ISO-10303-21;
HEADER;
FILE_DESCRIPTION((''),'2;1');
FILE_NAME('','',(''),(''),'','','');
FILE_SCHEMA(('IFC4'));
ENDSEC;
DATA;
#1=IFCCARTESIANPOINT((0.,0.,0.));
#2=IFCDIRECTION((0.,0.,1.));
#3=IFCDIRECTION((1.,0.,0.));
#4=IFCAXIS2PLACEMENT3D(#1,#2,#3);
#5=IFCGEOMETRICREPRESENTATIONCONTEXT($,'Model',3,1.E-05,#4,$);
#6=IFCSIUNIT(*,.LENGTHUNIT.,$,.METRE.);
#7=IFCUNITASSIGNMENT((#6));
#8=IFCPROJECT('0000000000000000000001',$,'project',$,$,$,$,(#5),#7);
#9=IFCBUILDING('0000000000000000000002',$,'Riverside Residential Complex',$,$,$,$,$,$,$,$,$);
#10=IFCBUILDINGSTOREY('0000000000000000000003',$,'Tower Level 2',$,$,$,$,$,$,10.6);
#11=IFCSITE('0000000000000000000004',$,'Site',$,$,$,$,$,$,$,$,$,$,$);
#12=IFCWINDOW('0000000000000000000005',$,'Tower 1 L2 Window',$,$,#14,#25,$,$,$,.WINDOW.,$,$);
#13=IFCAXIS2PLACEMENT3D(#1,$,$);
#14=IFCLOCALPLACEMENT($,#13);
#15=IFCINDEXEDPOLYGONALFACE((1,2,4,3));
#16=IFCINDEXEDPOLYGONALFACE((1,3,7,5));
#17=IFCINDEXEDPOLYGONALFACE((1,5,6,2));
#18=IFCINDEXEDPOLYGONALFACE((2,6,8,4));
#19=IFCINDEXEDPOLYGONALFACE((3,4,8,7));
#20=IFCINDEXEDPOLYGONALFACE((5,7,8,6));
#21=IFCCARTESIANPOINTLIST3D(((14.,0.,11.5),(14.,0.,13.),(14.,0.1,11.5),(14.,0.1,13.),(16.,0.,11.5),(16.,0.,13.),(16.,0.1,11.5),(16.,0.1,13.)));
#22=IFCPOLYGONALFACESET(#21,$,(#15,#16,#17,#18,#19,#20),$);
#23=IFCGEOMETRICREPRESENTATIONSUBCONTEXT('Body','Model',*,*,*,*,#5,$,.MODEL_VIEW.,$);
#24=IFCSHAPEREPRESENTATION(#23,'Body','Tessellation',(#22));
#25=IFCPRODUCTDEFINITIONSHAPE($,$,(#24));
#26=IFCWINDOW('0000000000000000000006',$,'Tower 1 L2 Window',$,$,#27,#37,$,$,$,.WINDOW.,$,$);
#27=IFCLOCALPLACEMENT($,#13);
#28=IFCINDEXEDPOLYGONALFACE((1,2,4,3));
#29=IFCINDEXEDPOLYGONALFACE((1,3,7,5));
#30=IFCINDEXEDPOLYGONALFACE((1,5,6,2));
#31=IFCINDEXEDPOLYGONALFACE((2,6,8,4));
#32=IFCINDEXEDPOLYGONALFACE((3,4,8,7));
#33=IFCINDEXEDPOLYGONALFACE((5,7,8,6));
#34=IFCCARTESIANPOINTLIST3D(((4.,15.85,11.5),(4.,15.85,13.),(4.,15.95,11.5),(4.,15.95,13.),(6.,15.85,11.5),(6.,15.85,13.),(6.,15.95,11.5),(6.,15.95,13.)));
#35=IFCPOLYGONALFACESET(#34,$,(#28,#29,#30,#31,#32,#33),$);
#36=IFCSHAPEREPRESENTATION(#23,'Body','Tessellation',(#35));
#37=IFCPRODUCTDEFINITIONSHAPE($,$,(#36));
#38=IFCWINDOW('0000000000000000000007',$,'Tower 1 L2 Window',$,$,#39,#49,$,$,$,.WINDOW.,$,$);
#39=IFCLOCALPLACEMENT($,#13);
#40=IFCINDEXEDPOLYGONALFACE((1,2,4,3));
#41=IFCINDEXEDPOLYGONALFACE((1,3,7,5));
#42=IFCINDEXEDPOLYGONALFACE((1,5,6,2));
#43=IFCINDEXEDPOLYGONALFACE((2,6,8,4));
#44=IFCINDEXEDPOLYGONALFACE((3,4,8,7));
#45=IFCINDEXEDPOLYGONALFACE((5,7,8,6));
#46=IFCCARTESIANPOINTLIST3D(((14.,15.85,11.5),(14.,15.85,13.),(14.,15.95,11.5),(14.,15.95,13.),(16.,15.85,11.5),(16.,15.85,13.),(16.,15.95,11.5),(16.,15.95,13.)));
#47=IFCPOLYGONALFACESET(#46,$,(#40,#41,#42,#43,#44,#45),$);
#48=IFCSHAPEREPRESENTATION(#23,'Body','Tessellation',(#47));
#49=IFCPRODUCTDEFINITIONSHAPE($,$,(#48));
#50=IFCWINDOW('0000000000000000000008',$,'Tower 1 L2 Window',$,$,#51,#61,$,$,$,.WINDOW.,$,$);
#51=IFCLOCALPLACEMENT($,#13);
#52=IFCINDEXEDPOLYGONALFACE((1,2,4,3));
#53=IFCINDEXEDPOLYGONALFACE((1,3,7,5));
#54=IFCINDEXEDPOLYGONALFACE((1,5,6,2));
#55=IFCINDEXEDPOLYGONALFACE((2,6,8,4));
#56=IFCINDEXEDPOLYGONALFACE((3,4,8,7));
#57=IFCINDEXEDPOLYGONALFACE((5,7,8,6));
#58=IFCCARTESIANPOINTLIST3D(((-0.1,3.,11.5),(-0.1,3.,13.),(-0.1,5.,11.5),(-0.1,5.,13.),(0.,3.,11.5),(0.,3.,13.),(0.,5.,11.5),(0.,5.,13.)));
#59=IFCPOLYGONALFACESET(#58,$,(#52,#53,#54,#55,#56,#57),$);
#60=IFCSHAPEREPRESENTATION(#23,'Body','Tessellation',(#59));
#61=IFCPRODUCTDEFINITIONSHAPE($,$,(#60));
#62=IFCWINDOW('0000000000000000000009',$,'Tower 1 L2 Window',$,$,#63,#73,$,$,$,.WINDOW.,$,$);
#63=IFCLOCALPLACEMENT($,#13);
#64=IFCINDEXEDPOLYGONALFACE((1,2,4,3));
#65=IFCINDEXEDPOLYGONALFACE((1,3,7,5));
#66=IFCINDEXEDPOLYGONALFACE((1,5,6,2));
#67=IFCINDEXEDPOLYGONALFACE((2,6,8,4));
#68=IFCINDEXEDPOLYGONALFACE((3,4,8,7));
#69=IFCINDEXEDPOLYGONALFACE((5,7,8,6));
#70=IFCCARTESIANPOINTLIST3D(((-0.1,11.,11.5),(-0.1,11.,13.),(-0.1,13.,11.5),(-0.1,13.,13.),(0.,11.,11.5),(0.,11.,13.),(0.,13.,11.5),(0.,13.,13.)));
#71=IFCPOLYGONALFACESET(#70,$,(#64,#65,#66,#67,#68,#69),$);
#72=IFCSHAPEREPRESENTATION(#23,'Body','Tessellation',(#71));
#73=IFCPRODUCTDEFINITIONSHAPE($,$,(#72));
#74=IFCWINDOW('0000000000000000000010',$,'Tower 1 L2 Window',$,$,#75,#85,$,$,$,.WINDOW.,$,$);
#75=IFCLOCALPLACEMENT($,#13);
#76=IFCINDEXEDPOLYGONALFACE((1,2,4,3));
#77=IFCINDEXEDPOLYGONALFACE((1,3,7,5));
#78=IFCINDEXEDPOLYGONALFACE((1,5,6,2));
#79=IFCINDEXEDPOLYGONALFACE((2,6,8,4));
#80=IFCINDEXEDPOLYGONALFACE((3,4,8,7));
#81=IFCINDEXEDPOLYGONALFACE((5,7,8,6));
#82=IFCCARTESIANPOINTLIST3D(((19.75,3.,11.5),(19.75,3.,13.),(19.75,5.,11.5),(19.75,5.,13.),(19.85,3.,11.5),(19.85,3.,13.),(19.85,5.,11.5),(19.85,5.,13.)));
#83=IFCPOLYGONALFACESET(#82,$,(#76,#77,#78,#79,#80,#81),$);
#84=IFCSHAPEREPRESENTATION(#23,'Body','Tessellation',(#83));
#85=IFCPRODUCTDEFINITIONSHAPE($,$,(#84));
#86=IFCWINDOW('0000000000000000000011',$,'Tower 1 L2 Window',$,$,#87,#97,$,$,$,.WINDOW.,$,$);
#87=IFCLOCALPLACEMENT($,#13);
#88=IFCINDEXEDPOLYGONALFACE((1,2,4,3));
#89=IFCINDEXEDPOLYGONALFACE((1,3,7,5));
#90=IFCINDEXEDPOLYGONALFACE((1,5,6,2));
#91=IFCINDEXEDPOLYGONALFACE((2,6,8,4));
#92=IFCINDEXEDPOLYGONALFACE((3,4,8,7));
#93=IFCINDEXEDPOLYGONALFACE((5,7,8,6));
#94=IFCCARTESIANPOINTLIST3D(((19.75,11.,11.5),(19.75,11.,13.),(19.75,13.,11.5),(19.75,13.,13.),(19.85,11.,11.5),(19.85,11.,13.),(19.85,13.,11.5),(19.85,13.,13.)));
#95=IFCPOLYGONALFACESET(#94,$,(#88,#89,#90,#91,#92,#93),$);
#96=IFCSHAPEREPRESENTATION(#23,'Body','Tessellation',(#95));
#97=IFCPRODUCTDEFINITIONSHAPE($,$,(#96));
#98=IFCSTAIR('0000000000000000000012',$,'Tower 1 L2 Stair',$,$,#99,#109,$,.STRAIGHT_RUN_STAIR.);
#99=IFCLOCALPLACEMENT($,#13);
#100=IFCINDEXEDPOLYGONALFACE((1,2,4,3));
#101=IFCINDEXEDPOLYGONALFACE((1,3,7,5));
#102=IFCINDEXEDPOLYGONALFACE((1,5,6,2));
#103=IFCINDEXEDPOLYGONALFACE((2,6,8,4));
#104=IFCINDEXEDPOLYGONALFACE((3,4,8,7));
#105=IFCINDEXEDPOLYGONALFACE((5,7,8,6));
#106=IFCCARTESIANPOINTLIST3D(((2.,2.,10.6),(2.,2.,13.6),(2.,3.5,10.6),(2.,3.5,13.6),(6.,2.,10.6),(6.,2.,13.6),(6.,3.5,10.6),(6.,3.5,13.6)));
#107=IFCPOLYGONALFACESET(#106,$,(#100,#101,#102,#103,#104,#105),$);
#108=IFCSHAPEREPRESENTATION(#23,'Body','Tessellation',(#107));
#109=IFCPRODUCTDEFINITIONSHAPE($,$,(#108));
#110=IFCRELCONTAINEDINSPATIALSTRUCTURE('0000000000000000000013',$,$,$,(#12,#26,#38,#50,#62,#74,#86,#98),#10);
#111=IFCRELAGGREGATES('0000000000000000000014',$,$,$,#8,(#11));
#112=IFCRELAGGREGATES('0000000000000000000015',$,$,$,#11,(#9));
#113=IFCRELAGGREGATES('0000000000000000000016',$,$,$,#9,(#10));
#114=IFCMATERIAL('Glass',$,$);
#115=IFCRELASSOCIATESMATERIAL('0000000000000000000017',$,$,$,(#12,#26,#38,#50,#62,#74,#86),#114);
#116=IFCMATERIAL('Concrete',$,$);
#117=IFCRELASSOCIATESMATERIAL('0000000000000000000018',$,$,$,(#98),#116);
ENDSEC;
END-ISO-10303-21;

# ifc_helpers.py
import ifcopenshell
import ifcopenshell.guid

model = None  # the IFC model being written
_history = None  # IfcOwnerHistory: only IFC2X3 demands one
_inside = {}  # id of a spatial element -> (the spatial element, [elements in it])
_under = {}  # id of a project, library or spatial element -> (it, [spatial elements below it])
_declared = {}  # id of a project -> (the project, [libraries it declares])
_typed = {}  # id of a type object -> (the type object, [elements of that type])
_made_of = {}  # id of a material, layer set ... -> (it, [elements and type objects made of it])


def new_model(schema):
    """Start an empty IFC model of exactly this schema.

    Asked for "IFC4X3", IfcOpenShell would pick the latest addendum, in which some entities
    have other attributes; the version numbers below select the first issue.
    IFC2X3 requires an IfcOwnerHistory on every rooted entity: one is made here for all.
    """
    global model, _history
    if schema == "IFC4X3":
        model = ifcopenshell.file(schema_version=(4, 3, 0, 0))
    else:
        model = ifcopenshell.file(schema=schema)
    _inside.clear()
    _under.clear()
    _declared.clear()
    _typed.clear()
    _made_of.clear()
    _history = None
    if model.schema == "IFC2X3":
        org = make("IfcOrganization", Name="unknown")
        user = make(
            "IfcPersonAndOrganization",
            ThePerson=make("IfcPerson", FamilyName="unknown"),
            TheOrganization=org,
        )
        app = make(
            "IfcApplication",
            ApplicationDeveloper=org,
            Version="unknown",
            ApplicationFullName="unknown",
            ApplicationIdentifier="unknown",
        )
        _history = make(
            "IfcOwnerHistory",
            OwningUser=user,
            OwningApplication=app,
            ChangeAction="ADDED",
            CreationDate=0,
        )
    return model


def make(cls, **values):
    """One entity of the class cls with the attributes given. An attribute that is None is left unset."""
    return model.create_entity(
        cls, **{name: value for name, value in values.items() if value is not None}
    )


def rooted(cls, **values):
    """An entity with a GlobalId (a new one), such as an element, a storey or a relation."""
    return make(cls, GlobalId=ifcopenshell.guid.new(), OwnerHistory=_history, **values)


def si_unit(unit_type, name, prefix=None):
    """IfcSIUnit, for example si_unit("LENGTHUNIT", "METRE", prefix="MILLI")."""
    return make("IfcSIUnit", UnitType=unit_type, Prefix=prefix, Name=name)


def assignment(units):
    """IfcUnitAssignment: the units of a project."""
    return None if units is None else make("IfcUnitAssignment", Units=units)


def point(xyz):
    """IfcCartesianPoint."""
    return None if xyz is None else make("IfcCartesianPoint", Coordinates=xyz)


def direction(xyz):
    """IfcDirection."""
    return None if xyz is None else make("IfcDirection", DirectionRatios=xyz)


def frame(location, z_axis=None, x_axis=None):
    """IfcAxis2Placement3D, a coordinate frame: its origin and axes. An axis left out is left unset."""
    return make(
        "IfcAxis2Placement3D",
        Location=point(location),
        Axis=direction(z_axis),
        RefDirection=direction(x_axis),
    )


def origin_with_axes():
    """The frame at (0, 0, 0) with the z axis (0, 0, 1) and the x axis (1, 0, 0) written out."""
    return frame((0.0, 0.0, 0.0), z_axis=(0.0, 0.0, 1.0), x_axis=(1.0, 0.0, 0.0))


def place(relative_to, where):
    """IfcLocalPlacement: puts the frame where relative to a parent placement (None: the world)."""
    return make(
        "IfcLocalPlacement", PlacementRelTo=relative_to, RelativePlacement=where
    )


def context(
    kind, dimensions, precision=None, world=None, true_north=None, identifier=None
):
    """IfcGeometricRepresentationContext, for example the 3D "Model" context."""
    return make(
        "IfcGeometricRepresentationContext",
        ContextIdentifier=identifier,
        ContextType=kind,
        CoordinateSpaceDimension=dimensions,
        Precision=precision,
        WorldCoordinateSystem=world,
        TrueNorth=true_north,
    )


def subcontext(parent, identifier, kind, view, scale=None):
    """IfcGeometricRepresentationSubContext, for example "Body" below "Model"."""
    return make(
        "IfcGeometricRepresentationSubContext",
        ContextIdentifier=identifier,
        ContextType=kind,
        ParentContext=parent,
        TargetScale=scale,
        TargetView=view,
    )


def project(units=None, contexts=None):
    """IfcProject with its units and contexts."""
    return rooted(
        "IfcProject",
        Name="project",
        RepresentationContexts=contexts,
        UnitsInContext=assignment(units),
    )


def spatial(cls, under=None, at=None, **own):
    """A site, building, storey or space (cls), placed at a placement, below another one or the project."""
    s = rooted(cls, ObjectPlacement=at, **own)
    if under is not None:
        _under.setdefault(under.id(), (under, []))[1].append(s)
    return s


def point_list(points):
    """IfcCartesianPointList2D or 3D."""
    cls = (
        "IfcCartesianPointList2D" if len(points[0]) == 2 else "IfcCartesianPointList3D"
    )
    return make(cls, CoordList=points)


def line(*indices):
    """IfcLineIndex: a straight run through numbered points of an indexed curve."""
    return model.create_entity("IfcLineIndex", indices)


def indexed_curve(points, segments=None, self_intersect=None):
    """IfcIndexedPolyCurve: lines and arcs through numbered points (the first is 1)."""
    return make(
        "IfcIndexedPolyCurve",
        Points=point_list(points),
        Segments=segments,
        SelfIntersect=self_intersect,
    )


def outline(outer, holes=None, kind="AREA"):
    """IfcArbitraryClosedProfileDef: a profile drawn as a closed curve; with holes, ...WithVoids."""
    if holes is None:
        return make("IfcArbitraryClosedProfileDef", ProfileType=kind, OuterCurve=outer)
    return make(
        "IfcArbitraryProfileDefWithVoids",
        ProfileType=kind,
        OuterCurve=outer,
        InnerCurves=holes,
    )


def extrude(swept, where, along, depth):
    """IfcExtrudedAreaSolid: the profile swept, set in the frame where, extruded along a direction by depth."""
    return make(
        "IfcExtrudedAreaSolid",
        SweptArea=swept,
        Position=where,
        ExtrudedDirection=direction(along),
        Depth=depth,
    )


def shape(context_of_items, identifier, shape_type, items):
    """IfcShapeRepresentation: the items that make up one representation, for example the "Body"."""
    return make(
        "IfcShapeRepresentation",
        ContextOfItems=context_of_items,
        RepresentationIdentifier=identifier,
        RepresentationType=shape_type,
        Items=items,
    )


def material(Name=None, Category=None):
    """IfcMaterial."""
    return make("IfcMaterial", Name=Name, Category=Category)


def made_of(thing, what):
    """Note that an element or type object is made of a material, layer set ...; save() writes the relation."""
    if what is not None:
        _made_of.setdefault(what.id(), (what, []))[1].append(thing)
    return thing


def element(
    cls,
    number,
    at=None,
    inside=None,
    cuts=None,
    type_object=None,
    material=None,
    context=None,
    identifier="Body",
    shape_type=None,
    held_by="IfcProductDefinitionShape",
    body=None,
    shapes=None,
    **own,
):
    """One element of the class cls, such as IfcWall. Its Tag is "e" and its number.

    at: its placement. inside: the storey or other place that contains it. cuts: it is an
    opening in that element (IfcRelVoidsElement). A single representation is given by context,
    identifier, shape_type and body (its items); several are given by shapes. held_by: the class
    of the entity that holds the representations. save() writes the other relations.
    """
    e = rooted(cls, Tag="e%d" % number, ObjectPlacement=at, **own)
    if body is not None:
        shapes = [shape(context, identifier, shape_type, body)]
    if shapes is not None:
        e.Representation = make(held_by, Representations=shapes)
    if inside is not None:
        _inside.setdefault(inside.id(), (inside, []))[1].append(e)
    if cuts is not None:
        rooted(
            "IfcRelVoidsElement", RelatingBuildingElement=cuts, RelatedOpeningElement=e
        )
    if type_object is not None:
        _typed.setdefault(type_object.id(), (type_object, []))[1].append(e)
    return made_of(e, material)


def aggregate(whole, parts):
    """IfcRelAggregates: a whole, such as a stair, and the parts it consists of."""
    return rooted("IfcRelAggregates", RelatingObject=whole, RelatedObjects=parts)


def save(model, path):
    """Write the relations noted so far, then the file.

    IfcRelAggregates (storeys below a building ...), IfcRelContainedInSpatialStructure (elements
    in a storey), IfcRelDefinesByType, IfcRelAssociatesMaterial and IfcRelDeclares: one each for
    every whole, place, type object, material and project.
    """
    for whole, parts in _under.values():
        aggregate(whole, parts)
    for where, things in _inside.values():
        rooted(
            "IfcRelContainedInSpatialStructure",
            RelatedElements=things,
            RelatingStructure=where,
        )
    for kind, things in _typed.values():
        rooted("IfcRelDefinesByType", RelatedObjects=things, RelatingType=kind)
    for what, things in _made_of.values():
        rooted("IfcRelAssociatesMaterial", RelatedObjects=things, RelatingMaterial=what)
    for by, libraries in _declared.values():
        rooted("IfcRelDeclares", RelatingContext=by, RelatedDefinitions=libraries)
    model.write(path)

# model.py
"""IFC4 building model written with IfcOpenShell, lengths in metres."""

from ifc_helpers import new_model, si_unit, frame, origin_with_axes, place, context, subcontext, project, spatial, line, indexed_curve, outline, extrude, material, element, save


model = new_model("IFC4")

# Units and contexts
model_context = context("Model", 3, precision=1e-05, world=origin_with_axes())
body_context = subcontext(model_context, "Body", "Model", "MODEL_VIEW")
ifc_project = project(units=[si_unit("LENGTHUNIT", "METRE")], contexts=[model_context])

# Site, building, storey
site = spatial("IfcSite", under=ifc_project, Name="Site")
building = spatial("IfcBuilding", under=site, Name="Riverside Residential Complex")
storey = spatial("IfcBuildingStorey", under=building, Name="Tower Level 2", Elevation=10.6)

# Shared definitions
ifc_material_1 = material(Name="Concrete")

# Windows
ifc_material_2 = material(Name="Glass")
for number, where, z_axis, x_axis, name in (
    (1, (14.0, 0.0, 11.5), (0.0, 0.0, 1.0), (1.0, 0.0, 0.0), "Tower 1 L2 Window"),
    (2, (4.0, 15.85, 11.5), (0.0, 0.0, 1.0), (1.0, 0.0, 0.0), "Tower 1 L2 Window"),
    (3, (14.0, 15.85, 11.5), (0.0, 0.0, 1.0), (1.0, 0.0, 0.0), "Tower 1 L2 Window"),
    (4, (0.0, 3.0, 11.5), (0.0, 0.0, 1.0), (0.0, 1.0, 0.0), "Tower 1 L2 Window"),
    (5, (0.0, 11.0, 11.5), (0.0, 0.0, 1.0), (0.0, 1.0, 0.0), "Tower 1 L2 Window"),
    (6, (19.85, 3.0, 11.5), (0.0, 0.0, 1.0), (0.0, 1.0, 0.0), "Tower 1 L2 Window"),
    (7, (19.85, 11.0, 11.5), (0.0, 0.0, 1.0), (0.0, 1.0, 0.0), "Tower 1 L2 Window"),
):
    element("IfcWindow", number, at=place(None, frame(where, z_axis=z_axis, x_axis=x_axis)), inside=storey, material=ifc_material_2, Name=name, PredefinedType="WINDOW", context=body_context, shape_type="SweptSolid", body=[
        extrude(outline(indexed_curve([(0.0, 0.0), (2.0, 0.0), (2.0, 0.1), (0.0, 0.1)], segments=[line(1, 2, 3, 4, 1)])), origin_with_axes(), (0.0, 0.0, 1.0), 1.5),
    ])

# Stair
stair_placement = place(None, frame((2.0, 2.0, 10.6), z_axis=(0.0, 0.0, 1.0), x_axis=(1.0, 0.0, 0.0)))
element("IfcStair", 8, at=stair_placement, inside=storey, material=ifc_material_1, Name="Tower 1 L2 Stair", PredefinedType="STRAIGHT_RUN_STAIR", context=body_context, shape_type="SweptSolid", body=[
    extrude(outline(indexed_curve([(0.0, 0.0), (4.0, 0.0), (4.0, 1.5), (0.0, 1.5)], segments=[line(1, 2, 3, 4, 1)])), origin_with_axes(), (0.0, 0.0, 1.0), 3.0),
])

save(model, "model.ifc")
